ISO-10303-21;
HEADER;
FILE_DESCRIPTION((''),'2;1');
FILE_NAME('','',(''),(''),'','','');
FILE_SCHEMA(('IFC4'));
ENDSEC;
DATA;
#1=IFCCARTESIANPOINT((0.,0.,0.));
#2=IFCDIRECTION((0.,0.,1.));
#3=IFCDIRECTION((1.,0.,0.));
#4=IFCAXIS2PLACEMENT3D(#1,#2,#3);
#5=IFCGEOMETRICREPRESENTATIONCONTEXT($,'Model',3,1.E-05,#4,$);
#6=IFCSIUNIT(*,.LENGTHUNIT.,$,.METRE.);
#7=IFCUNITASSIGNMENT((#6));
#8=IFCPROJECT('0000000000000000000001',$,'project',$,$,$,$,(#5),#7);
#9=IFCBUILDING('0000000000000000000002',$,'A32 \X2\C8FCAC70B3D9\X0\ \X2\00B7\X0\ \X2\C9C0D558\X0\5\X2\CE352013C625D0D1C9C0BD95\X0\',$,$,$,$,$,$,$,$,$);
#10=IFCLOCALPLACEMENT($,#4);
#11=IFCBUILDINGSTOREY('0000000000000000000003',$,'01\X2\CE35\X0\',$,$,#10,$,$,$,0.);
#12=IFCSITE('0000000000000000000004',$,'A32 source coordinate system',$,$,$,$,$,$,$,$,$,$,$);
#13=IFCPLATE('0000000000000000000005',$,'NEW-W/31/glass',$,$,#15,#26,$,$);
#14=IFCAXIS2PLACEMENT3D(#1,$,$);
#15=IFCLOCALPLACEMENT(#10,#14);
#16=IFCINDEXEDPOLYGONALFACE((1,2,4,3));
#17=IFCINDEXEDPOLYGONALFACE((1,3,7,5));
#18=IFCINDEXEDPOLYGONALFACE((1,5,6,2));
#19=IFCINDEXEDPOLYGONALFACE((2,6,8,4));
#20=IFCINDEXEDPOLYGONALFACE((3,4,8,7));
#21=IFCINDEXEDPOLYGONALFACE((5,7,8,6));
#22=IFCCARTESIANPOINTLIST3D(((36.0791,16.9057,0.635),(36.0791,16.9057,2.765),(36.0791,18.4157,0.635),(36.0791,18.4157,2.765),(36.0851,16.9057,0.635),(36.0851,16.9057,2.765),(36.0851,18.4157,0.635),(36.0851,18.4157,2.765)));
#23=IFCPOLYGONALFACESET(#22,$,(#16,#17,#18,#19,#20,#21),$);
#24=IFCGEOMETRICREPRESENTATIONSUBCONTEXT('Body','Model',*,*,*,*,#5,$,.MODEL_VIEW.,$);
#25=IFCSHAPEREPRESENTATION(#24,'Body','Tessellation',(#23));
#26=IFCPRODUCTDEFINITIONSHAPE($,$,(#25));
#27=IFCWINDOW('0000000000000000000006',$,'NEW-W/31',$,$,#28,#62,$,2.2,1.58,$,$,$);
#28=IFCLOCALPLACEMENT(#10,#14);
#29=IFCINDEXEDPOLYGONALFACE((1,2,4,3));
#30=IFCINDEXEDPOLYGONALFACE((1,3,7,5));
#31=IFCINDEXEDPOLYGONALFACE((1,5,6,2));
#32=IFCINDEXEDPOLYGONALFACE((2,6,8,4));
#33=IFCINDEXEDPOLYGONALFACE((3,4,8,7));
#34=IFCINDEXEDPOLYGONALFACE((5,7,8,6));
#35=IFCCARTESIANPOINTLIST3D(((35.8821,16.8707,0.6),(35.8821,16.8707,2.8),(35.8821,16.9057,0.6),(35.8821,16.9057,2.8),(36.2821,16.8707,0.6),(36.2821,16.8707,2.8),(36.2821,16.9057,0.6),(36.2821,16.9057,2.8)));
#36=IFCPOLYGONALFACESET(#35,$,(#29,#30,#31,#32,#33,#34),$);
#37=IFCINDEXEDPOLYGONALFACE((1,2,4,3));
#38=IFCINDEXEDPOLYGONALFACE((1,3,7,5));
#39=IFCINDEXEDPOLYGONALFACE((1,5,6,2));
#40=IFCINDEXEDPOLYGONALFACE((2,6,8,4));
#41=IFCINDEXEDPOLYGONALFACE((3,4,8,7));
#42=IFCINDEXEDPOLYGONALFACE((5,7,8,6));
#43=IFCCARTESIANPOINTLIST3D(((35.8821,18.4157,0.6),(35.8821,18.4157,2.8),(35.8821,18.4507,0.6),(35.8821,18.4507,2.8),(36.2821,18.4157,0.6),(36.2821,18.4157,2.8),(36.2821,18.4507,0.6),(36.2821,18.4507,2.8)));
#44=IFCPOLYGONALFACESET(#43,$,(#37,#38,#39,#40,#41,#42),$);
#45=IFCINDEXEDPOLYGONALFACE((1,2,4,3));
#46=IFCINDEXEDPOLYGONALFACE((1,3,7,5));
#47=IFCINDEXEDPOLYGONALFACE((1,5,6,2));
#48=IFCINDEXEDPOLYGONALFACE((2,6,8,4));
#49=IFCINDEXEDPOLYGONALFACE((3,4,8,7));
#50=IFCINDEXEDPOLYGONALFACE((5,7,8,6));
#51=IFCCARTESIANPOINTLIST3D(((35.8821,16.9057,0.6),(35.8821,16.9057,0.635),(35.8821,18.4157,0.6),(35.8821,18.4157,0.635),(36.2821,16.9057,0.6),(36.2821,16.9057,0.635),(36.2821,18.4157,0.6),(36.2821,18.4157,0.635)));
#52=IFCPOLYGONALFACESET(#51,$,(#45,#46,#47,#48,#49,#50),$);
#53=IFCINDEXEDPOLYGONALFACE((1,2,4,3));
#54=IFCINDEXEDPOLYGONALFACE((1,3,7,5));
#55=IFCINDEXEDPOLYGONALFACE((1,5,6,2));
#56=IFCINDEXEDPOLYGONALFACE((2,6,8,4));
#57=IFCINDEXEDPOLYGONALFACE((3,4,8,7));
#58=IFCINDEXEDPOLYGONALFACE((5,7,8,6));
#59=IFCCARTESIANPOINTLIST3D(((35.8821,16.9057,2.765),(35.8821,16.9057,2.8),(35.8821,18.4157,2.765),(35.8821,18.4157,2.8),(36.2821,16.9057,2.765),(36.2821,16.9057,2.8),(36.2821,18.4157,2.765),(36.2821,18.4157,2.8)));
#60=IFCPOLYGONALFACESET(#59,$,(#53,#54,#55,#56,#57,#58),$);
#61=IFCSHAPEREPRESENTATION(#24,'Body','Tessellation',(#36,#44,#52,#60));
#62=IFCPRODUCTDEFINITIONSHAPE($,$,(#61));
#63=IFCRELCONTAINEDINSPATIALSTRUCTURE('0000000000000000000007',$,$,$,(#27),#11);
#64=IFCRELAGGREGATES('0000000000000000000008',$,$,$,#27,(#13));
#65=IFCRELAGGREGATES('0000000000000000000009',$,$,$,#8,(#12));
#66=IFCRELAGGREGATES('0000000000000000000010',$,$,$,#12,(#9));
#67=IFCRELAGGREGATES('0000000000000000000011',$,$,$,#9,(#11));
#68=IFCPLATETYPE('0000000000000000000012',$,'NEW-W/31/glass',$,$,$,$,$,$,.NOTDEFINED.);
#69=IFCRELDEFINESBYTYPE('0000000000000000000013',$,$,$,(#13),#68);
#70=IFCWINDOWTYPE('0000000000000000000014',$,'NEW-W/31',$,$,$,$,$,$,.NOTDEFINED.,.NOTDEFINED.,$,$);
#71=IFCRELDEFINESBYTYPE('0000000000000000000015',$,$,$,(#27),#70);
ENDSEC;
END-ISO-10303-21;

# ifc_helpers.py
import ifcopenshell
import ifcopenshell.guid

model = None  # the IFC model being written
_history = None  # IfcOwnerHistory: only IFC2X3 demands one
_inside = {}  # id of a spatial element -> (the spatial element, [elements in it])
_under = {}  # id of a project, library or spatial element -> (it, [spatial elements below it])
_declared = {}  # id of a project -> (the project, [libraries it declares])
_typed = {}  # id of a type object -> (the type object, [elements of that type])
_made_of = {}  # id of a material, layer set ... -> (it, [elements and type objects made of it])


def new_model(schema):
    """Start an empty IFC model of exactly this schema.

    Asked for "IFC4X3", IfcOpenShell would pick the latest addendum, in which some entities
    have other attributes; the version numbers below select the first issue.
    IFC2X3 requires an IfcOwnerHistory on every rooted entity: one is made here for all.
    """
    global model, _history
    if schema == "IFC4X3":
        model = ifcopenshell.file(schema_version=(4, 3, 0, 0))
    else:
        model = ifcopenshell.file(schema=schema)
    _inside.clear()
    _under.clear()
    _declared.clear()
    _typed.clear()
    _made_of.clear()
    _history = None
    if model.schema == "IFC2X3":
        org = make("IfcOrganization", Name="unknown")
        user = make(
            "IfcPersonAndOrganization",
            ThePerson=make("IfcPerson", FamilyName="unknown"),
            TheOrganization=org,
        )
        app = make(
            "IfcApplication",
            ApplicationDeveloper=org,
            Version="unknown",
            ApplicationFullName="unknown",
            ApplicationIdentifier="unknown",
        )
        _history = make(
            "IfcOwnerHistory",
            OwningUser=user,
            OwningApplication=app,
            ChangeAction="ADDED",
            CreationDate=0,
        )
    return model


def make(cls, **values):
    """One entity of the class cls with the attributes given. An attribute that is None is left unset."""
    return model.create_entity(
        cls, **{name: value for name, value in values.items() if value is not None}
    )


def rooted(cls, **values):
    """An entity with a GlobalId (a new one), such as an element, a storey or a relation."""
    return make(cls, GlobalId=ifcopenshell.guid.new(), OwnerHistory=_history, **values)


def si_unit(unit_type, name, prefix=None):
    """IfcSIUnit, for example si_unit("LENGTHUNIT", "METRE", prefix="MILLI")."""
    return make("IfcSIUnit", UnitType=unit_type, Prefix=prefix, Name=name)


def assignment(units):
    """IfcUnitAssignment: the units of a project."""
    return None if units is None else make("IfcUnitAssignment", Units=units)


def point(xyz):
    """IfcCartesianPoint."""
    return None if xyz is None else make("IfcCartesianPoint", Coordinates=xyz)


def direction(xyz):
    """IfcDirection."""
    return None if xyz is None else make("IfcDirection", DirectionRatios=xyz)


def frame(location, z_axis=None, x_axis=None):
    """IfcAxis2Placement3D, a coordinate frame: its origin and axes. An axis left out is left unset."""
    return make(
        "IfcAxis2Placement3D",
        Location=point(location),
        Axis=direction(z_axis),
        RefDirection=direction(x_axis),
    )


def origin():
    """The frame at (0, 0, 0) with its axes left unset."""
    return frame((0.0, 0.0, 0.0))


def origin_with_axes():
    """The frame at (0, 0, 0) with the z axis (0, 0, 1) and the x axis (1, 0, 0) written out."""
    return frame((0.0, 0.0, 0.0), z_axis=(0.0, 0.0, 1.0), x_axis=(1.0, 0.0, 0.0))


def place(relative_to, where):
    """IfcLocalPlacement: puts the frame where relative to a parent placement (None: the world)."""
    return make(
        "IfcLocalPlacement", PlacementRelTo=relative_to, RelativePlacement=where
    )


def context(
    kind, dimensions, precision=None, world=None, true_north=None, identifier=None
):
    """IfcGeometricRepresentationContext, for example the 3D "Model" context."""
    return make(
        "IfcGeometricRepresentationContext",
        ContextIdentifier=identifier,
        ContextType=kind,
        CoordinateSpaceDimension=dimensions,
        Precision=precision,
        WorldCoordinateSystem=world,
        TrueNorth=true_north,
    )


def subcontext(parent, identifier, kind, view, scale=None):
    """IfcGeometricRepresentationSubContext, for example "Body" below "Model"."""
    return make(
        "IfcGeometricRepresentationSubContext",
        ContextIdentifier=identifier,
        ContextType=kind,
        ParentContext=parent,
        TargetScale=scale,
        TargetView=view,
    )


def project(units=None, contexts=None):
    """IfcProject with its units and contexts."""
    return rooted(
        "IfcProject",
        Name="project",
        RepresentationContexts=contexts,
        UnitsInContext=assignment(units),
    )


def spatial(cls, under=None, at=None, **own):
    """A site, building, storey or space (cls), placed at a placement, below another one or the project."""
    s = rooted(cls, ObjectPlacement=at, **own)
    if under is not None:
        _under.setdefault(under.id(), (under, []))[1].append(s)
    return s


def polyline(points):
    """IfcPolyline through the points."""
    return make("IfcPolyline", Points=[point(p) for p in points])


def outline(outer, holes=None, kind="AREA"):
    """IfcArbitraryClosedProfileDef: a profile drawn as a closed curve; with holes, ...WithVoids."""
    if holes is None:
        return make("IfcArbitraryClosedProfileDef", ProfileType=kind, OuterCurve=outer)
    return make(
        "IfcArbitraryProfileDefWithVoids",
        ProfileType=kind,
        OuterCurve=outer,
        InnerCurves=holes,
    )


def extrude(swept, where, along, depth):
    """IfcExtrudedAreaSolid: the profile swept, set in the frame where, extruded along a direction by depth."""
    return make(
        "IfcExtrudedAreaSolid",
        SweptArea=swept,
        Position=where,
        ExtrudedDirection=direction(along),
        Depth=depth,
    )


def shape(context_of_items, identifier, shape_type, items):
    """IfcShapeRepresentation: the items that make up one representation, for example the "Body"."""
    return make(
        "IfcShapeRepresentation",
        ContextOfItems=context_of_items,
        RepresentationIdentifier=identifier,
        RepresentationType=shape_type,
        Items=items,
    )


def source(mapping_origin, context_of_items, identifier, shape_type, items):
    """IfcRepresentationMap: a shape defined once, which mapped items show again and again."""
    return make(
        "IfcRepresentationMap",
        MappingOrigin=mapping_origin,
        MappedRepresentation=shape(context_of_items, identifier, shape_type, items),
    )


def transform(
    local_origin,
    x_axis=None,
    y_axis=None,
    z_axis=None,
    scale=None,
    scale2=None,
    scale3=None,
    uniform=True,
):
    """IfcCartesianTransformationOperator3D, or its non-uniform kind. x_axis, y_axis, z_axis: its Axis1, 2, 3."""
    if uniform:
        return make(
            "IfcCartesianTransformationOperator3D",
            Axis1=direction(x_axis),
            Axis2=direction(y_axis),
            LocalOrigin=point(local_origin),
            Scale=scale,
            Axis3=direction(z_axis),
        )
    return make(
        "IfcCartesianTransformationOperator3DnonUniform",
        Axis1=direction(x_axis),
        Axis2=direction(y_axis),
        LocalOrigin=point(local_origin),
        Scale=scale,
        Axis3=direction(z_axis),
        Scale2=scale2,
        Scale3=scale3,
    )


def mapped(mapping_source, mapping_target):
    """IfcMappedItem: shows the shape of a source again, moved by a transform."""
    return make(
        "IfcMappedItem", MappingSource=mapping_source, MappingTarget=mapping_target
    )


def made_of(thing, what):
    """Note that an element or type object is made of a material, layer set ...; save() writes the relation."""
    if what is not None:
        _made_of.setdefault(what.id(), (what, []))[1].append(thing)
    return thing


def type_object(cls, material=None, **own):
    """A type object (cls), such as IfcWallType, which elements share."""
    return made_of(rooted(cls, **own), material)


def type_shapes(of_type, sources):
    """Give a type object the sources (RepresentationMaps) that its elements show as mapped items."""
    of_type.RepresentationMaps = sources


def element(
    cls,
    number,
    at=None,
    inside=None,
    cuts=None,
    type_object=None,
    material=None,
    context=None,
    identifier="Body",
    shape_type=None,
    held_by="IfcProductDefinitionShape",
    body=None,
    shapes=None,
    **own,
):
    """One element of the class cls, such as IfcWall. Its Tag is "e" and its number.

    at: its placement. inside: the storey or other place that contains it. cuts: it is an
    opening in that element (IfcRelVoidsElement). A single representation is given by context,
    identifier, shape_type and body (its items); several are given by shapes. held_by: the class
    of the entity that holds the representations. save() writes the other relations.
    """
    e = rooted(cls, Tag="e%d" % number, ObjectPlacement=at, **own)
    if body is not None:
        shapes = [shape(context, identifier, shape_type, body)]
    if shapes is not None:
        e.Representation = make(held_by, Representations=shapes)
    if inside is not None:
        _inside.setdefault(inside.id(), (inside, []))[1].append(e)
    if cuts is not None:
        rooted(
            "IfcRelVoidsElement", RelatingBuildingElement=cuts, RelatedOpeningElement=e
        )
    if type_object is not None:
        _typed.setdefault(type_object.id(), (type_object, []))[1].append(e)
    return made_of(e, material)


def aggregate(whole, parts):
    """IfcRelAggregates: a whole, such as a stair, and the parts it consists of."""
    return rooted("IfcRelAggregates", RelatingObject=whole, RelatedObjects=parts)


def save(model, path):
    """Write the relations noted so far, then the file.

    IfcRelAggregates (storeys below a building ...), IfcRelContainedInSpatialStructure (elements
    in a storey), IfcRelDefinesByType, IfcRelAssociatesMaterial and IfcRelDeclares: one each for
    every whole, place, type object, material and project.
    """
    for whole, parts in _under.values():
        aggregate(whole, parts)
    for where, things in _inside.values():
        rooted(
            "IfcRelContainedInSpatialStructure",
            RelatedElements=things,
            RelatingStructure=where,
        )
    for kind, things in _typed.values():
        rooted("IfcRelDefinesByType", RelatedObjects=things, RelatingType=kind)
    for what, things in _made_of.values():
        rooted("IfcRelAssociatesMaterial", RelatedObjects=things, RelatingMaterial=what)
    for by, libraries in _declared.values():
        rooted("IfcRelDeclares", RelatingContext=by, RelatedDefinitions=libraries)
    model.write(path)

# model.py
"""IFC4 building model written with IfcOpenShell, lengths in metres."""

from ifc_helpers import new_model, si_unit, frame, origin, origin_with_axes, place, context, subcontext, project, spatial, polyline, outline, extrude, source, transform, mapped, type_object, type_shapes, element, aggregate, save


model = new_model("IFC4")

# Units and contexts
model_context = context("Model", 3, precision=1e-05, world=origin_with_axes())
body_context = subcontext(model_context, "Body", "Model", "MODEL_VIEW")
ifc_project = project(units=[si_unit("LENGTHUNIT", "METRE")], contexts=[model_context])

# Plate
storey_placement = place(None, origin_with_axes())
plate_type_1 = type_object("IfcPlateType", Name="NEW-W/31/glass", PredefinedType="NOTDEFINED")
shared_shape_1 = source(origin(), body_context, "Body", "SweptSolid", [
    extrude(outline(polyline([(36.0851, 16.9057), (36.0791, 16.9057), (36.0791, 18.4157), (36.0851, 18.4157), (36.0851, 16.9057)])), frame((0.0, 0.0, 0.635)), (0.0, 0.0, 1.0), 2.13),
])
type_shapes(plate_type_1, [shared_shape_1])
window_1_placement = place(storey_placement, origin_with_axes())
plate_1_placement = place(window_1_placement, origin_with_axes())
plate_1 = element("IfcPlate", 1, at=plate_1_placement, type_object=plate_type_1, Name="NEW-W/31/glass", context=body_context, shape_type="MappedRepresentation", body=[
    mapped(shared_shape_1, transform((0.0, 0.0, 0.0), scale=1.0)),
])

# Site, building, storey
site = spatial("IfcSite", under=ifc_project, Name="A32 source coordinate system")
building = spatial("IfcBuilding", under=site, Name="A32 주거동 · 지하5층–옥탑지붕")
storey = spatial("IfcBuildingStorey", under=building, at=storey_placement, Name="01층", Elevation=0.0)

# Window
window_type_1 = type_object("IfcWindowType", Name="NEW-W/31", PartitioningType="NOTDEFINED", PredefinedType="NOTDEFINED")
shared_shape_2 = source(origin(), body_context, "Body", "SweptSolid", [
    extrude(outline(polyline([(35.8821, 16.8707), (35.8821, 16.9057), (36.2821, 16.9057), (36.2821, 16.8707), (35.8821, 16.8707)])), frame((0.0, 0.0, 0.6)), (0.0, 0.0, 1.0), 2.2),
    extrude(outline(polyline([(35.8821, 18.4157), (35.8821, 18.4507), (36.2821, 18.4507), (36.2821, 18.4157), (35.8821, 18.4157)])), frame((0.0, 0.0, 0.6)), (0.0, 0.0, 1.0), 2.2),
    extrude(outline(polyline([(36.2821, 16.9057), (36.2821, 18.4157), (35.8821, 18.4157), (35.8821, 16.9057), (36.2821, 16.9057)])), frame((0.0, 0.0, 0.6)), (0.0, 0.0, 1.0), 0.035),
    extrude(outline(polyline([(36.2821, 16.9057), (36.2821, 18.4157), (35.8821, 18.4157), (35.8821, 16.9057), (36.2821, 16.9057)])), frame((0.0, 0.0, 2.765)), (0.0, 0.0, 1.0), 0.035),
])
type_shapes(window_type_1, [shared_shape_2])
window_1 = element("IfcWindow", 2, at=window_1_placement, inside=storey, type_object=window_type_1, Name="NEW-W/31", OverallHeight=2.2, OverallWidth=1.58, context=body_context, shape_type="MappedRepresentation", body=[
    mapped(shared_shape_2, transform((0.0, 0.0, 0.0), scale=1.0)),
])
aggregate(window_1, [plate_1])

save(model, "model.ifc")
